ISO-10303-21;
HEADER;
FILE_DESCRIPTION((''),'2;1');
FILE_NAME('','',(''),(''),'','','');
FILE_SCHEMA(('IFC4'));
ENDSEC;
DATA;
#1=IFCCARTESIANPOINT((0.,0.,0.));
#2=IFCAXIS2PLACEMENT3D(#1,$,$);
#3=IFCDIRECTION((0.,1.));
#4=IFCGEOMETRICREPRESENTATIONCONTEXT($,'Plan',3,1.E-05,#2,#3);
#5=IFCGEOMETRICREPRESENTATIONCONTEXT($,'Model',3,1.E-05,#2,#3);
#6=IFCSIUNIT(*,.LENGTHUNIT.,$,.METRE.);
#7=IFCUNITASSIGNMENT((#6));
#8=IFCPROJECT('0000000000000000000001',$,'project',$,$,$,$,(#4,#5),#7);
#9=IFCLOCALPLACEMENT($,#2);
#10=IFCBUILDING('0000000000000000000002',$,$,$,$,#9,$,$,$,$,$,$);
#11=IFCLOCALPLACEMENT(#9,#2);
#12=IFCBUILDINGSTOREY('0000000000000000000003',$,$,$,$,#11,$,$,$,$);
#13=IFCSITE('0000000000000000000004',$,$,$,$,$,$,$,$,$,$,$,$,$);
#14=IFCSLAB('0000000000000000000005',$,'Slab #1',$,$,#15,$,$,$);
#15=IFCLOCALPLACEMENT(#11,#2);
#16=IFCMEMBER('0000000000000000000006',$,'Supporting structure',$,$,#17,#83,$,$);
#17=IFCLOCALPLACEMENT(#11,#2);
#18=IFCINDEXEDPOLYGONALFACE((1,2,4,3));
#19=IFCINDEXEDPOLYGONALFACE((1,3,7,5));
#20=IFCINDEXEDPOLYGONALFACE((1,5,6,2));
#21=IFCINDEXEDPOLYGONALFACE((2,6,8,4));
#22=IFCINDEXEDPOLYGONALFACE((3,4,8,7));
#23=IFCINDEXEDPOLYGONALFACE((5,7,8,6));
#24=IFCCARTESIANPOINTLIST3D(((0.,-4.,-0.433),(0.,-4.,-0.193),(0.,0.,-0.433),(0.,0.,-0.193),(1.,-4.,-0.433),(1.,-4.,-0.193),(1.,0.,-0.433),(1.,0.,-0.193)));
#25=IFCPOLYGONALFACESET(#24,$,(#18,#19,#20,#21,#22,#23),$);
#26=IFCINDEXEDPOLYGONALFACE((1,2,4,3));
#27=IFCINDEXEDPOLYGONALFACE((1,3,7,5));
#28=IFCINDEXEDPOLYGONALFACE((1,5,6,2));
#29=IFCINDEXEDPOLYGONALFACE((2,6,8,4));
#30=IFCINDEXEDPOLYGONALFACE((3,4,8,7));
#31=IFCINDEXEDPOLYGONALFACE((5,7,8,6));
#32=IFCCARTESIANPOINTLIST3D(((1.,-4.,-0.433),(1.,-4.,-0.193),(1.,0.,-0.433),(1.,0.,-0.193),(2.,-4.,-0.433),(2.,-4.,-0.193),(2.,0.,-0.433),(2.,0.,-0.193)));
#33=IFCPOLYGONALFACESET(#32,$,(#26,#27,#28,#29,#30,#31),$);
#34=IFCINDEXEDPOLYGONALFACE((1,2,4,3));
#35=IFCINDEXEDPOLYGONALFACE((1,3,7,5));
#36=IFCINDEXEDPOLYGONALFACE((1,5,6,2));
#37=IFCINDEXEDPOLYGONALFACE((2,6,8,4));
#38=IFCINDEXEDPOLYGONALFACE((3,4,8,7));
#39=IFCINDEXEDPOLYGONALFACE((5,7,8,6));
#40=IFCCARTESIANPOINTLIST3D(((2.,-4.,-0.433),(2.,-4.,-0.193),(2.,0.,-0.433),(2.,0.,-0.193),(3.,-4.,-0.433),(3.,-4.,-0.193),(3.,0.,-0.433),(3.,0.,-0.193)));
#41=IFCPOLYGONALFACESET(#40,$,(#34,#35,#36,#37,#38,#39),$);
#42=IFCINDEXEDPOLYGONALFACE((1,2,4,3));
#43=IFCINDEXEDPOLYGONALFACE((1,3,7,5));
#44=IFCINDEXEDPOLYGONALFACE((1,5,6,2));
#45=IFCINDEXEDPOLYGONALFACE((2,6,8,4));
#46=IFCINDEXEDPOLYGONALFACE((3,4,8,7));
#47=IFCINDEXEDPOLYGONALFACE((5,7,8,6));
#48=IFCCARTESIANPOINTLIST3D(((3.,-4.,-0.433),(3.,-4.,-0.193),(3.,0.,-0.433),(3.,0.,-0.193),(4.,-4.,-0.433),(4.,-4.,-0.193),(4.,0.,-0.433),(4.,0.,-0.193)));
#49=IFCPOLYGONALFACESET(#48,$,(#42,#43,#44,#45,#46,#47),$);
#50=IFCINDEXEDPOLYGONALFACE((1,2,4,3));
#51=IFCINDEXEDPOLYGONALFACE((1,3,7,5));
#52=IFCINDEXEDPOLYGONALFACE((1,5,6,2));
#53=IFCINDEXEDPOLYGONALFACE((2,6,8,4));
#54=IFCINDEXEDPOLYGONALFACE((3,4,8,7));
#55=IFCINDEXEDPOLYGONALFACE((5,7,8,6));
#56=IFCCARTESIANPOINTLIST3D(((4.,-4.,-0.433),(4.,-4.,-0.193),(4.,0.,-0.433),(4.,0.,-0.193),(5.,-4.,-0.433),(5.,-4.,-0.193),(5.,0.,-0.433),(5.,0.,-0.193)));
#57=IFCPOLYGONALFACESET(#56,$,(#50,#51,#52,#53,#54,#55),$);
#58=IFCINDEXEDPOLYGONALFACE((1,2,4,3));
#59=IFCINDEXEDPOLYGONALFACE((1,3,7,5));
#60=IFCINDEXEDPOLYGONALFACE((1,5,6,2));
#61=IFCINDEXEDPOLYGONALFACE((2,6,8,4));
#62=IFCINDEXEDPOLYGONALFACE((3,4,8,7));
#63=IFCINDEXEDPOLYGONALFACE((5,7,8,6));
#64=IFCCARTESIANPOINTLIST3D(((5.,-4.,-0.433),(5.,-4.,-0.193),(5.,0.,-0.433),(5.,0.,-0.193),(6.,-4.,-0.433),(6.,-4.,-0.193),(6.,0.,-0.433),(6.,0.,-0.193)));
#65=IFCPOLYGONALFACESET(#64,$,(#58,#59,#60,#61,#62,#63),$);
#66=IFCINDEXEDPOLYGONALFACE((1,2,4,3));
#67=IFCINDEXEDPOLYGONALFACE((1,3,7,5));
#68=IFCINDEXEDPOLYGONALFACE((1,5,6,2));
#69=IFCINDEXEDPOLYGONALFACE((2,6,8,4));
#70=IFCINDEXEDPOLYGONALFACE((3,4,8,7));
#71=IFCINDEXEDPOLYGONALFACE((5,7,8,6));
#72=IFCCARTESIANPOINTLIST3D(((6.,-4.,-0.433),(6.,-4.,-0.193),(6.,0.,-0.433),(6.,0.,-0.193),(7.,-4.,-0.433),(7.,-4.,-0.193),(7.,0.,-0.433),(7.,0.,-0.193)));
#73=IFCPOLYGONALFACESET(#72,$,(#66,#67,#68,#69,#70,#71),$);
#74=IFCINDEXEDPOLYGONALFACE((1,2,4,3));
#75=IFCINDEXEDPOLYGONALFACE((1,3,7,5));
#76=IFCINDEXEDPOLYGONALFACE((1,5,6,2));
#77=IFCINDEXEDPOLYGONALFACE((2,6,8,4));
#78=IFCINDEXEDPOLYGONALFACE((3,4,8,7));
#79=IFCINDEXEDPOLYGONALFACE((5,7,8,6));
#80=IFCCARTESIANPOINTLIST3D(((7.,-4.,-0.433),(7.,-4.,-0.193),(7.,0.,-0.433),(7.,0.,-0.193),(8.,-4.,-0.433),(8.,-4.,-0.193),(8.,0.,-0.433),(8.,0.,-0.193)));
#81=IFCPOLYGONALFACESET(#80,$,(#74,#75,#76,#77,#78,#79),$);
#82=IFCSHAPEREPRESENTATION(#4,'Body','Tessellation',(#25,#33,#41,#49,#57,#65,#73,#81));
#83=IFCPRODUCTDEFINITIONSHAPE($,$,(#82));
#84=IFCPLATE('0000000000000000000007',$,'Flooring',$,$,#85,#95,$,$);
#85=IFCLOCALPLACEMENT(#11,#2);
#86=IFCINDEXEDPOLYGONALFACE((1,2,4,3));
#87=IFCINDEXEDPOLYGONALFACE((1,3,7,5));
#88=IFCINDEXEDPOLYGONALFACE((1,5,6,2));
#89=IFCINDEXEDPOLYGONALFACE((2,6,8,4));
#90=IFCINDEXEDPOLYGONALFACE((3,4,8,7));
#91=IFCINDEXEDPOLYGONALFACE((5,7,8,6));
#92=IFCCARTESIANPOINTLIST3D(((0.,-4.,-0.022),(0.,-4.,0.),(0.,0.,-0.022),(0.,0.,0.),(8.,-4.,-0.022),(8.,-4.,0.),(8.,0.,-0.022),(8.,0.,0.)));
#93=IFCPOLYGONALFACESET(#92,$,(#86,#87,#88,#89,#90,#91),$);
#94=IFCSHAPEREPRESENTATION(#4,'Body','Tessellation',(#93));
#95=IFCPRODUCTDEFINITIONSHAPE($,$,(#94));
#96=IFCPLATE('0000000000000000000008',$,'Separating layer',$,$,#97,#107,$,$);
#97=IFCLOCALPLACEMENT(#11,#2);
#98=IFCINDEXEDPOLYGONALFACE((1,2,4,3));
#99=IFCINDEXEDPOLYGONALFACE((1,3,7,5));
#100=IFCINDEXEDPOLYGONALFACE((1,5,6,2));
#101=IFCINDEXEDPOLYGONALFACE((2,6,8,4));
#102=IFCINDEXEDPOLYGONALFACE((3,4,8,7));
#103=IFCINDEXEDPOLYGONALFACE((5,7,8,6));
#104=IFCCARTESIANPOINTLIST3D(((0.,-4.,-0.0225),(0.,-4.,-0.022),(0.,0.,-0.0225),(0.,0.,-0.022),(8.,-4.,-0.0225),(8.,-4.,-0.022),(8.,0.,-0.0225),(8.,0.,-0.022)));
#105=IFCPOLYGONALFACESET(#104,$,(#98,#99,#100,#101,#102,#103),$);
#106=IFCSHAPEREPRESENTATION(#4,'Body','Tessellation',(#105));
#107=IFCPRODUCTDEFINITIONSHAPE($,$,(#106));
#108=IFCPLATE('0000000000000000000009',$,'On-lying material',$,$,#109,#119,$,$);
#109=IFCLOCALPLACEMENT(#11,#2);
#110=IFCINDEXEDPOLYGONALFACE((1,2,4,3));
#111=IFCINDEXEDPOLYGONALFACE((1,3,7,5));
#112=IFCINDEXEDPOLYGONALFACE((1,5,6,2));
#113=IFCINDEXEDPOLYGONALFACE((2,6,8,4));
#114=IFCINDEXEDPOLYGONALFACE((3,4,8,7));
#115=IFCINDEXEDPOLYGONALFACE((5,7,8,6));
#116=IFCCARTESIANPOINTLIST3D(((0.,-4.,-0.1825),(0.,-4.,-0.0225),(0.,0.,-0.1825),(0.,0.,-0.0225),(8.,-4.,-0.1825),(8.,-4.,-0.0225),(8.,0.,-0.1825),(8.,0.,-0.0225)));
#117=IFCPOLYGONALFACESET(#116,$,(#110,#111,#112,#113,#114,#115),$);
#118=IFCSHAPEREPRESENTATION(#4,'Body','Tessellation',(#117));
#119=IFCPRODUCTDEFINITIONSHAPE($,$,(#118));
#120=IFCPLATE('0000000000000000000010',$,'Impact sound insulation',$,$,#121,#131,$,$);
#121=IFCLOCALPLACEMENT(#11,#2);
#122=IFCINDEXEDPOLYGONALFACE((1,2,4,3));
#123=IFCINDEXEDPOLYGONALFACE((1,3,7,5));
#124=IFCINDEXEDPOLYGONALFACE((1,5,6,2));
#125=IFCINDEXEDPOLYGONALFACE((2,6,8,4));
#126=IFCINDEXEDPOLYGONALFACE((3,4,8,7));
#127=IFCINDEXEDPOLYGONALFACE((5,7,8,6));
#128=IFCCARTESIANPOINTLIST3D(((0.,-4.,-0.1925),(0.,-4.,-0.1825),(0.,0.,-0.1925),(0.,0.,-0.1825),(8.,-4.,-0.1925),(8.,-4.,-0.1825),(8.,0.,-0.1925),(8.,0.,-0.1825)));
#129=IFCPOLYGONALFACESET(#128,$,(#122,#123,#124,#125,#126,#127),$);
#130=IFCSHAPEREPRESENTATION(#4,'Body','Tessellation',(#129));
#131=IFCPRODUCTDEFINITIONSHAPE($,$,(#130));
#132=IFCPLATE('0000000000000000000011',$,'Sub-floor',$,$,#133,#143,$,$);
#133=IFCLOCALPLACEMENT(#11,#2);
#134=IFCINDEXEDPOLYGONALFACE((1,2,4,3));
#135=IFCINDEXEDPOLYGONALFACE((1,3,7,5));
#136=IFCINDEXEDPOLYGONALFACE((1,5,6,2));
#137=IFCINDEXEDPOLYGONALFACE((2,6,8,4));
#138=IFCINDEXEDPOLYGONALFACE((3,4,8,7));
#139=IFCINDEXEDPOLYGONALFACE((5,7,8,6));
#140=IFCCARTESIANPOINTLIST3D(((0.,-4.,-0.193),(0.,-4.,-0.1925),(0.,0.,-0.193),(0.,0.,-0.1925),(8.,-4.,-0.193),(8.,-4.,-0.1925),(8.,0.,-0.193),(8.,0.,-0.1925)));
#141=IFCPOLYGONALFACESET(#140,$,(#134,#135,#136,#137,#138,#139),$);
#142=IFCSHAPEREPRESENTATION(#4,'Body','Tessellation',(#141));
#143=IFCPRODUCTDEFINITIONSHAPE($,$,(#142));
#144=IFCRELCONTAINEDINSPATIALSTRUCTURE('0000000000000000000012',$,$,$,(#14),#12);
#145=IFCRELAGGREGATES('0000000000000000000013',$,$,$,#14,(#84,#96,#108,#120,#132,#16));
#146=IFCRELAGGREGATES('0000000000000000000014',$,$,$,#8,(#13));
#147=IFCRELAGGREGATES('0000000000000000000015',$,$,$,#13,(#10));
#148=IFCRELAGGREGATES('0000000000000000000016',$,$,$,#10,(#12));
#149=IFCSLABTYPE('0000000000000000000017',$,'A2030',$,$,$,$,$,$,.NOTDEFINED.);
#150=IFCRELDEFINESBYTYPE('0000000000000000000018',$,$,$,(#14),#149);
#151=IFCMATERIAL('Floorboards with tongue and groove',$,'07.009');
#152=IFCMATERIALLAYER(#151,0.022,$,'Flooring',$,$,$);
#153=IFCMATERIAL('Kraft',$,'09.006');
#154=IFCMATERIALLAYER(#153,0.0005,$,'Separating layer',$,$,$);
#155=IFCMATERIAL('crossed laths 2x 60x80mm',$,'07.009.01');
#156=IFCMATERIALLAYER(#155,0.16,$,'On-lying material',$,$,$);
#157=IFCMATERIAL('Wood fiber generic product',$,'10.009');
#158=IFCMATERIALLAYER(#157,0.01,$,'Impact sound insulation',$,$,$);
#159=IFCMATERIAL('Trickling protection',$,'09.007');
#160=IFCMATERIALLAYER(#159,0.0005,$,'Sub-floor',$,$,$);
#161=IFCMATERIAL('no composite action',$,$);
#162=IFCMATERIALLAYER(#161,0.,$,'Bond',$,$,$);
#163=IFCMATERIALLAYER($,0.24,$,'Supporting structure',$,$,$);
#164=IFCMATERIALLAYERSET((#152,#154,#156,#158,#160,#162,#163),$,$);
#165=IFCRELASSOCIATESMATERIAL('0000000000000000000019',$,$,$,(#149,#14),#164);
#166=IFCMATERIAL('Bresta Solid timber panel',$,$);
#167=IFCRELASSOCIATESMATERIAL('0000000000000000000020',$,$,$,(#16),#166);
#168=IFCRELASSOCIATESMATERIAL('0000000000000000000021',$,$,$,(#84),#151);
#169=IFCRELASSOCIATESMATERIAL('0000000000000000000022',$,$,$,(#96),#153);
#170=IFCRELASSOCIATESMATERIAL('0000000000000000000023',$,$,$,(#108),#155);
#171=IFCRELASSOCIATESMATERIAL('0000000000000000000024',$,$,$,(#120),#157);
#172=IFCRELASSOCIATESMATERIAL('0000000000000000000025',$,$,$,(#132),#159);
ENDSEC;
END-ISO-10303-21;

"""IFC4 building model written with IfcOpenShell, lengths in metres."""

from ifc_helpers import new_model, si_unit, direction, frame, frame_2d, origin, origin_with_axes, place, context, project, spatial, rectangle, extrude, material, layer, layer_set, type_object, element, aggregate, save


model = new_model("IFC4")

# Units and contexts
plan_context = context("Plan", 3, precision=1e-05, world=origin(), true_north=direction((0.0, 1.0)))
model_context = context("Model", 3, precision=1e-05, world=origin(), true_north=direction((0.0, 1.0)))
ifc_project = project(units=[si_unit("LENGTHUNIT", "METRE")], contexts=[plan_context, model_context])

# Site, building, storey
site = spatial("IfcSite", under=ifc_project)
building_placement = place(None, origin())
building = spatial("IfcBuilding", under=site, at=building_placement)
storey_placement = place(building_placement, origin())
storey = spatial("IfcBuildingStorey", under=building, at=storey_placement)

# Slab, member, plates
ifc_material_1 = material(Name="Floorboards with tongue and groove", Category="07.009")
ifc_layer_1 = layer(ifc_material_1, 0.022, Name="Flooring")
ifc_material_2 = material(Name="Kraft", Category="09.006")
ifc_layer_2 = layer(ifc_material_2, 0.0005, Name="Separating layer")
ifc_material_3 = material(Name="crossed laths 2x 60x80mm", Category="07.009.01")
ifc_layer_3 = layer(ifc_material_3, 0.16, Name="On-lying material")
ifc_material_4 = material(Name="Wood fiber generic product", Category="10.009")
ifc_layer_4 = layer(ifc_material_4, 0.01, Name="Impact sound insulation")
ifc_material_5 = material(Name="Trickling protection", Category="09.007")
ifc_layer_5 = layer(ifc_material_5, 0.0005, Name="Sub-floor")
ifc_material_6 = material(Name="no composite action")
ifc_layer_6 = layer(ifc_material_6, 0.0, Name="Bond")
ifc_layer_7 = layer(None, 0.24, Name="Supporting structure")
ifc_layer_set = layer_set([ifc_layer_1, ifc_layer_2, ifc_layer_3, ifc_layer_4, ifc_layer_5, ifc_layer_6, ifc_layer_7])
slab_type = type_object("IfcSlabType", Name="A2030", PredefinedType="NOTDEFINED", material=ifc_layer_set)
slab_placement = place(None, frame((0.0, 0.0, 0.0), z_axis=(0.0, 0.0, -1.0), x_axis=(1.0, 0.0, 0.0)))
slab = element("IfcSlab", 1, at=slab_placement, inside=storey, type_object=slab_type, material=ifc_layer_set, Name="Slab #1")
ifc_material_7 = material(Name="Bresta Solid timber panel")
member_placement = place(slab_placement, origin())
member = element("IfcMember", 2, at=member_placement, material=ifc_material_7, Name="Supporting structure", context=plan_context, shape_type="SweptSolid", body=[
    extrude(rectangle(XDim=1.0, YDim=0.24, at=frame_2d((0.5, 0.12), x_axis=(1.0, 0.0))), frame((0.0, 4.0, 0.193), z_axis=(0.0, -1.0, 0.0), x_axis=(1.0, 0.0, 0.0)), (0.0, 0.0, 1.0), 4.0),
    extrude(rectangle(XDim=1.0, YDim=0.24, at=frame_2d((0.5, 0.12), x_axis=(1.0, 0.0))), frame((1.0, 4.0, 0.193), z_axis=(0.0, -1.0, 0.0), x_axis=(1.0, 0.0, 0.0)), (0.0, 0.0, 1.0), 4.0),
    extrude(rectangle(XDim=1.0, YDim=0.24, at=frame_2d((0.5, 0.12), x_axis=(1.0, 0.0))), frame((2.0, 4.0, 0.193), z_axis=(0.0, -1.0, 0.0), x_axis=(1.0, 0.0, 0.0)), (0.0, 0.0, 1.0), 4.0),
    extrude(rectangle(XDim=1.0, YDim=0.24, at=frame_2d((0.5, 0.12), x_axis=(1.0, 0.0))), frame((3.0, 4.0, 0.193), z_axis=(0.0, -1.0, 0.0), x_axis=(1.0, 0.0, 0.0)), (0.0, 0.0, 1.0), 4.0),
    extrude(rectangle(XDim=1.0, YDim=0.24, at=frame_2d((0.5, 0.12), x_axis=(1.0, 0.0))), frame((4.0, 4.0, 0.193), z_axis=(0.0, -1.0, 0.0), x_axis=(1.0, 0.0, 0.0)), (0.0, 0.0, 1.0), 4.0),
    extrude(rectangle(XDim=1.0, YDim=0.24, at=frame_2d((0.5, 0.12), x_axis=(1.0, 0.0))), frame((5.0, 4.0, 0.193), z_axis=(0.0, -1.0, 0.0), x_axis=(1.0, 0.0, 0.0)), (0.0, 0.0, 1.0), 4.0),
    extrude(rectangle(XDim=1.0, YDim=0.24, at=frame_2d((0.5, 0.12), x_axis=(1.0, 0.0))), frame((6.0, 4.0, 0.193), z_axis=(0.0, -1.0, 0.0), x_axis=(1.0, 0.0, 0.0)), (0.0, 0.0, 1.0), 4.0),
    extrude(rectangle(XDim=1.0, YDim=0.24, at=frame_2d((0.5, 0.12), x_axis=(1.0, 0.0))), frame((7.0, 4.0, 0.193), z_axis=(0.0, -1.0, 0.0), x_axis=(1.0, 0.0, 0.0)), (0.0, 0.0, 1.0), 4.0),
])
plate_1_placement = place(slab_placement, origin())
plate_1 = element("IfcPlate", 3, at=plate_1_placement, material=ifc_material_1, Name="Flooring", context=plan_context, shape_type="SweptSolid", body=[
    extrude(rectangle(XDim=8.0, YDim=4.0, at=frame_2d((4.0, 2.0), x_axis=(1.0, 0.0))), origin_with_axes(), (0.0, 0.0, 1.0), 0.022),
])
plate_2_placement = place(slab_placement, origin())
plate_2 = element("IfcPlate", 4, at=plate_2_placement, material=ifc_material_2, Name="Separating layer", context=plan_context, shape_type="SweptSolid", body=[
    extrude(rectangle(XDim=8.0, YDim=4.0, at=frame_2d((4.0, 2.0), x_axis=(1.0, 0.0))), frame((0.0, 0.0, 0.022), z_axis=(0.0, 0.0, 1.0), x_axis=(1.0, 0.0, 0.0)), (0.0, 0.0, 1.0), 0.0005),
])
plate_3_placement = place(slab_placement, origin())
plate_3 = element("IfcPlate", 5, at=plate_3_placement, material=ifc_material_3, Name="On-lying material", context=plan_context, shape_type="SweptSolid", body=[
    extrude(rectangle(XDim=8.0, YDim=4.0, at=frame_2d((4.0, 2.0), x_axis=(1.0, 0.0))), frame((0.0, 0.0, 0.0225), z_axis=(0.0, 0.0, 1.0), x_axis=(1.0, 0.0, 0.0)), (0.0, 0.0, 1.0), 0.16),
])
plate_4_placement = place(slab_placement, origin())
plate_4 = element("IfcPlate", 6, at=plate_4_placement, material=ifc_material_4, Name="Impact sound insulation", context=plan_context, shape_type="SweptSolid", body=[
    extrude(rectangle(XDim=8.0, YDim=4.0, at=frame_2d((4.0, 2.0), x_axis=(1.0, 0.0))), frame((0.0, 0.0, 0.1825), z_axis=(0.0, 0.0, 1.0), x_axis=(1.0, 0.0, 0.0)), (0.0, 0.0, 1.0), 0.01),
])
plate_5_placement = place(slab_placement, origin())
plate_5 = element("IfcPlate", 7, at=plate_5_placement, material=ifc_material_5, Name="Sub-floor", context=plan_context, shape_type="SweptSolid", body=[
    extrude(rectangle(XDim=8.0, YDim=4.0, at=frame_2d((4.0, 2.0), x_axis=(1.0, 0.0))), frame((0.0, 0.0, 0.1925), z_axis=(0.0, 0.0, 1.0), x_axis=(1.0, 0.0, 0.0)), (0.0, 0.0, 1.0), 0.0005),
])
aggregate(slab, [plate_1, plate_2, plate_3, plate_4, plate_5, member])

save(model, "model.ifc")
